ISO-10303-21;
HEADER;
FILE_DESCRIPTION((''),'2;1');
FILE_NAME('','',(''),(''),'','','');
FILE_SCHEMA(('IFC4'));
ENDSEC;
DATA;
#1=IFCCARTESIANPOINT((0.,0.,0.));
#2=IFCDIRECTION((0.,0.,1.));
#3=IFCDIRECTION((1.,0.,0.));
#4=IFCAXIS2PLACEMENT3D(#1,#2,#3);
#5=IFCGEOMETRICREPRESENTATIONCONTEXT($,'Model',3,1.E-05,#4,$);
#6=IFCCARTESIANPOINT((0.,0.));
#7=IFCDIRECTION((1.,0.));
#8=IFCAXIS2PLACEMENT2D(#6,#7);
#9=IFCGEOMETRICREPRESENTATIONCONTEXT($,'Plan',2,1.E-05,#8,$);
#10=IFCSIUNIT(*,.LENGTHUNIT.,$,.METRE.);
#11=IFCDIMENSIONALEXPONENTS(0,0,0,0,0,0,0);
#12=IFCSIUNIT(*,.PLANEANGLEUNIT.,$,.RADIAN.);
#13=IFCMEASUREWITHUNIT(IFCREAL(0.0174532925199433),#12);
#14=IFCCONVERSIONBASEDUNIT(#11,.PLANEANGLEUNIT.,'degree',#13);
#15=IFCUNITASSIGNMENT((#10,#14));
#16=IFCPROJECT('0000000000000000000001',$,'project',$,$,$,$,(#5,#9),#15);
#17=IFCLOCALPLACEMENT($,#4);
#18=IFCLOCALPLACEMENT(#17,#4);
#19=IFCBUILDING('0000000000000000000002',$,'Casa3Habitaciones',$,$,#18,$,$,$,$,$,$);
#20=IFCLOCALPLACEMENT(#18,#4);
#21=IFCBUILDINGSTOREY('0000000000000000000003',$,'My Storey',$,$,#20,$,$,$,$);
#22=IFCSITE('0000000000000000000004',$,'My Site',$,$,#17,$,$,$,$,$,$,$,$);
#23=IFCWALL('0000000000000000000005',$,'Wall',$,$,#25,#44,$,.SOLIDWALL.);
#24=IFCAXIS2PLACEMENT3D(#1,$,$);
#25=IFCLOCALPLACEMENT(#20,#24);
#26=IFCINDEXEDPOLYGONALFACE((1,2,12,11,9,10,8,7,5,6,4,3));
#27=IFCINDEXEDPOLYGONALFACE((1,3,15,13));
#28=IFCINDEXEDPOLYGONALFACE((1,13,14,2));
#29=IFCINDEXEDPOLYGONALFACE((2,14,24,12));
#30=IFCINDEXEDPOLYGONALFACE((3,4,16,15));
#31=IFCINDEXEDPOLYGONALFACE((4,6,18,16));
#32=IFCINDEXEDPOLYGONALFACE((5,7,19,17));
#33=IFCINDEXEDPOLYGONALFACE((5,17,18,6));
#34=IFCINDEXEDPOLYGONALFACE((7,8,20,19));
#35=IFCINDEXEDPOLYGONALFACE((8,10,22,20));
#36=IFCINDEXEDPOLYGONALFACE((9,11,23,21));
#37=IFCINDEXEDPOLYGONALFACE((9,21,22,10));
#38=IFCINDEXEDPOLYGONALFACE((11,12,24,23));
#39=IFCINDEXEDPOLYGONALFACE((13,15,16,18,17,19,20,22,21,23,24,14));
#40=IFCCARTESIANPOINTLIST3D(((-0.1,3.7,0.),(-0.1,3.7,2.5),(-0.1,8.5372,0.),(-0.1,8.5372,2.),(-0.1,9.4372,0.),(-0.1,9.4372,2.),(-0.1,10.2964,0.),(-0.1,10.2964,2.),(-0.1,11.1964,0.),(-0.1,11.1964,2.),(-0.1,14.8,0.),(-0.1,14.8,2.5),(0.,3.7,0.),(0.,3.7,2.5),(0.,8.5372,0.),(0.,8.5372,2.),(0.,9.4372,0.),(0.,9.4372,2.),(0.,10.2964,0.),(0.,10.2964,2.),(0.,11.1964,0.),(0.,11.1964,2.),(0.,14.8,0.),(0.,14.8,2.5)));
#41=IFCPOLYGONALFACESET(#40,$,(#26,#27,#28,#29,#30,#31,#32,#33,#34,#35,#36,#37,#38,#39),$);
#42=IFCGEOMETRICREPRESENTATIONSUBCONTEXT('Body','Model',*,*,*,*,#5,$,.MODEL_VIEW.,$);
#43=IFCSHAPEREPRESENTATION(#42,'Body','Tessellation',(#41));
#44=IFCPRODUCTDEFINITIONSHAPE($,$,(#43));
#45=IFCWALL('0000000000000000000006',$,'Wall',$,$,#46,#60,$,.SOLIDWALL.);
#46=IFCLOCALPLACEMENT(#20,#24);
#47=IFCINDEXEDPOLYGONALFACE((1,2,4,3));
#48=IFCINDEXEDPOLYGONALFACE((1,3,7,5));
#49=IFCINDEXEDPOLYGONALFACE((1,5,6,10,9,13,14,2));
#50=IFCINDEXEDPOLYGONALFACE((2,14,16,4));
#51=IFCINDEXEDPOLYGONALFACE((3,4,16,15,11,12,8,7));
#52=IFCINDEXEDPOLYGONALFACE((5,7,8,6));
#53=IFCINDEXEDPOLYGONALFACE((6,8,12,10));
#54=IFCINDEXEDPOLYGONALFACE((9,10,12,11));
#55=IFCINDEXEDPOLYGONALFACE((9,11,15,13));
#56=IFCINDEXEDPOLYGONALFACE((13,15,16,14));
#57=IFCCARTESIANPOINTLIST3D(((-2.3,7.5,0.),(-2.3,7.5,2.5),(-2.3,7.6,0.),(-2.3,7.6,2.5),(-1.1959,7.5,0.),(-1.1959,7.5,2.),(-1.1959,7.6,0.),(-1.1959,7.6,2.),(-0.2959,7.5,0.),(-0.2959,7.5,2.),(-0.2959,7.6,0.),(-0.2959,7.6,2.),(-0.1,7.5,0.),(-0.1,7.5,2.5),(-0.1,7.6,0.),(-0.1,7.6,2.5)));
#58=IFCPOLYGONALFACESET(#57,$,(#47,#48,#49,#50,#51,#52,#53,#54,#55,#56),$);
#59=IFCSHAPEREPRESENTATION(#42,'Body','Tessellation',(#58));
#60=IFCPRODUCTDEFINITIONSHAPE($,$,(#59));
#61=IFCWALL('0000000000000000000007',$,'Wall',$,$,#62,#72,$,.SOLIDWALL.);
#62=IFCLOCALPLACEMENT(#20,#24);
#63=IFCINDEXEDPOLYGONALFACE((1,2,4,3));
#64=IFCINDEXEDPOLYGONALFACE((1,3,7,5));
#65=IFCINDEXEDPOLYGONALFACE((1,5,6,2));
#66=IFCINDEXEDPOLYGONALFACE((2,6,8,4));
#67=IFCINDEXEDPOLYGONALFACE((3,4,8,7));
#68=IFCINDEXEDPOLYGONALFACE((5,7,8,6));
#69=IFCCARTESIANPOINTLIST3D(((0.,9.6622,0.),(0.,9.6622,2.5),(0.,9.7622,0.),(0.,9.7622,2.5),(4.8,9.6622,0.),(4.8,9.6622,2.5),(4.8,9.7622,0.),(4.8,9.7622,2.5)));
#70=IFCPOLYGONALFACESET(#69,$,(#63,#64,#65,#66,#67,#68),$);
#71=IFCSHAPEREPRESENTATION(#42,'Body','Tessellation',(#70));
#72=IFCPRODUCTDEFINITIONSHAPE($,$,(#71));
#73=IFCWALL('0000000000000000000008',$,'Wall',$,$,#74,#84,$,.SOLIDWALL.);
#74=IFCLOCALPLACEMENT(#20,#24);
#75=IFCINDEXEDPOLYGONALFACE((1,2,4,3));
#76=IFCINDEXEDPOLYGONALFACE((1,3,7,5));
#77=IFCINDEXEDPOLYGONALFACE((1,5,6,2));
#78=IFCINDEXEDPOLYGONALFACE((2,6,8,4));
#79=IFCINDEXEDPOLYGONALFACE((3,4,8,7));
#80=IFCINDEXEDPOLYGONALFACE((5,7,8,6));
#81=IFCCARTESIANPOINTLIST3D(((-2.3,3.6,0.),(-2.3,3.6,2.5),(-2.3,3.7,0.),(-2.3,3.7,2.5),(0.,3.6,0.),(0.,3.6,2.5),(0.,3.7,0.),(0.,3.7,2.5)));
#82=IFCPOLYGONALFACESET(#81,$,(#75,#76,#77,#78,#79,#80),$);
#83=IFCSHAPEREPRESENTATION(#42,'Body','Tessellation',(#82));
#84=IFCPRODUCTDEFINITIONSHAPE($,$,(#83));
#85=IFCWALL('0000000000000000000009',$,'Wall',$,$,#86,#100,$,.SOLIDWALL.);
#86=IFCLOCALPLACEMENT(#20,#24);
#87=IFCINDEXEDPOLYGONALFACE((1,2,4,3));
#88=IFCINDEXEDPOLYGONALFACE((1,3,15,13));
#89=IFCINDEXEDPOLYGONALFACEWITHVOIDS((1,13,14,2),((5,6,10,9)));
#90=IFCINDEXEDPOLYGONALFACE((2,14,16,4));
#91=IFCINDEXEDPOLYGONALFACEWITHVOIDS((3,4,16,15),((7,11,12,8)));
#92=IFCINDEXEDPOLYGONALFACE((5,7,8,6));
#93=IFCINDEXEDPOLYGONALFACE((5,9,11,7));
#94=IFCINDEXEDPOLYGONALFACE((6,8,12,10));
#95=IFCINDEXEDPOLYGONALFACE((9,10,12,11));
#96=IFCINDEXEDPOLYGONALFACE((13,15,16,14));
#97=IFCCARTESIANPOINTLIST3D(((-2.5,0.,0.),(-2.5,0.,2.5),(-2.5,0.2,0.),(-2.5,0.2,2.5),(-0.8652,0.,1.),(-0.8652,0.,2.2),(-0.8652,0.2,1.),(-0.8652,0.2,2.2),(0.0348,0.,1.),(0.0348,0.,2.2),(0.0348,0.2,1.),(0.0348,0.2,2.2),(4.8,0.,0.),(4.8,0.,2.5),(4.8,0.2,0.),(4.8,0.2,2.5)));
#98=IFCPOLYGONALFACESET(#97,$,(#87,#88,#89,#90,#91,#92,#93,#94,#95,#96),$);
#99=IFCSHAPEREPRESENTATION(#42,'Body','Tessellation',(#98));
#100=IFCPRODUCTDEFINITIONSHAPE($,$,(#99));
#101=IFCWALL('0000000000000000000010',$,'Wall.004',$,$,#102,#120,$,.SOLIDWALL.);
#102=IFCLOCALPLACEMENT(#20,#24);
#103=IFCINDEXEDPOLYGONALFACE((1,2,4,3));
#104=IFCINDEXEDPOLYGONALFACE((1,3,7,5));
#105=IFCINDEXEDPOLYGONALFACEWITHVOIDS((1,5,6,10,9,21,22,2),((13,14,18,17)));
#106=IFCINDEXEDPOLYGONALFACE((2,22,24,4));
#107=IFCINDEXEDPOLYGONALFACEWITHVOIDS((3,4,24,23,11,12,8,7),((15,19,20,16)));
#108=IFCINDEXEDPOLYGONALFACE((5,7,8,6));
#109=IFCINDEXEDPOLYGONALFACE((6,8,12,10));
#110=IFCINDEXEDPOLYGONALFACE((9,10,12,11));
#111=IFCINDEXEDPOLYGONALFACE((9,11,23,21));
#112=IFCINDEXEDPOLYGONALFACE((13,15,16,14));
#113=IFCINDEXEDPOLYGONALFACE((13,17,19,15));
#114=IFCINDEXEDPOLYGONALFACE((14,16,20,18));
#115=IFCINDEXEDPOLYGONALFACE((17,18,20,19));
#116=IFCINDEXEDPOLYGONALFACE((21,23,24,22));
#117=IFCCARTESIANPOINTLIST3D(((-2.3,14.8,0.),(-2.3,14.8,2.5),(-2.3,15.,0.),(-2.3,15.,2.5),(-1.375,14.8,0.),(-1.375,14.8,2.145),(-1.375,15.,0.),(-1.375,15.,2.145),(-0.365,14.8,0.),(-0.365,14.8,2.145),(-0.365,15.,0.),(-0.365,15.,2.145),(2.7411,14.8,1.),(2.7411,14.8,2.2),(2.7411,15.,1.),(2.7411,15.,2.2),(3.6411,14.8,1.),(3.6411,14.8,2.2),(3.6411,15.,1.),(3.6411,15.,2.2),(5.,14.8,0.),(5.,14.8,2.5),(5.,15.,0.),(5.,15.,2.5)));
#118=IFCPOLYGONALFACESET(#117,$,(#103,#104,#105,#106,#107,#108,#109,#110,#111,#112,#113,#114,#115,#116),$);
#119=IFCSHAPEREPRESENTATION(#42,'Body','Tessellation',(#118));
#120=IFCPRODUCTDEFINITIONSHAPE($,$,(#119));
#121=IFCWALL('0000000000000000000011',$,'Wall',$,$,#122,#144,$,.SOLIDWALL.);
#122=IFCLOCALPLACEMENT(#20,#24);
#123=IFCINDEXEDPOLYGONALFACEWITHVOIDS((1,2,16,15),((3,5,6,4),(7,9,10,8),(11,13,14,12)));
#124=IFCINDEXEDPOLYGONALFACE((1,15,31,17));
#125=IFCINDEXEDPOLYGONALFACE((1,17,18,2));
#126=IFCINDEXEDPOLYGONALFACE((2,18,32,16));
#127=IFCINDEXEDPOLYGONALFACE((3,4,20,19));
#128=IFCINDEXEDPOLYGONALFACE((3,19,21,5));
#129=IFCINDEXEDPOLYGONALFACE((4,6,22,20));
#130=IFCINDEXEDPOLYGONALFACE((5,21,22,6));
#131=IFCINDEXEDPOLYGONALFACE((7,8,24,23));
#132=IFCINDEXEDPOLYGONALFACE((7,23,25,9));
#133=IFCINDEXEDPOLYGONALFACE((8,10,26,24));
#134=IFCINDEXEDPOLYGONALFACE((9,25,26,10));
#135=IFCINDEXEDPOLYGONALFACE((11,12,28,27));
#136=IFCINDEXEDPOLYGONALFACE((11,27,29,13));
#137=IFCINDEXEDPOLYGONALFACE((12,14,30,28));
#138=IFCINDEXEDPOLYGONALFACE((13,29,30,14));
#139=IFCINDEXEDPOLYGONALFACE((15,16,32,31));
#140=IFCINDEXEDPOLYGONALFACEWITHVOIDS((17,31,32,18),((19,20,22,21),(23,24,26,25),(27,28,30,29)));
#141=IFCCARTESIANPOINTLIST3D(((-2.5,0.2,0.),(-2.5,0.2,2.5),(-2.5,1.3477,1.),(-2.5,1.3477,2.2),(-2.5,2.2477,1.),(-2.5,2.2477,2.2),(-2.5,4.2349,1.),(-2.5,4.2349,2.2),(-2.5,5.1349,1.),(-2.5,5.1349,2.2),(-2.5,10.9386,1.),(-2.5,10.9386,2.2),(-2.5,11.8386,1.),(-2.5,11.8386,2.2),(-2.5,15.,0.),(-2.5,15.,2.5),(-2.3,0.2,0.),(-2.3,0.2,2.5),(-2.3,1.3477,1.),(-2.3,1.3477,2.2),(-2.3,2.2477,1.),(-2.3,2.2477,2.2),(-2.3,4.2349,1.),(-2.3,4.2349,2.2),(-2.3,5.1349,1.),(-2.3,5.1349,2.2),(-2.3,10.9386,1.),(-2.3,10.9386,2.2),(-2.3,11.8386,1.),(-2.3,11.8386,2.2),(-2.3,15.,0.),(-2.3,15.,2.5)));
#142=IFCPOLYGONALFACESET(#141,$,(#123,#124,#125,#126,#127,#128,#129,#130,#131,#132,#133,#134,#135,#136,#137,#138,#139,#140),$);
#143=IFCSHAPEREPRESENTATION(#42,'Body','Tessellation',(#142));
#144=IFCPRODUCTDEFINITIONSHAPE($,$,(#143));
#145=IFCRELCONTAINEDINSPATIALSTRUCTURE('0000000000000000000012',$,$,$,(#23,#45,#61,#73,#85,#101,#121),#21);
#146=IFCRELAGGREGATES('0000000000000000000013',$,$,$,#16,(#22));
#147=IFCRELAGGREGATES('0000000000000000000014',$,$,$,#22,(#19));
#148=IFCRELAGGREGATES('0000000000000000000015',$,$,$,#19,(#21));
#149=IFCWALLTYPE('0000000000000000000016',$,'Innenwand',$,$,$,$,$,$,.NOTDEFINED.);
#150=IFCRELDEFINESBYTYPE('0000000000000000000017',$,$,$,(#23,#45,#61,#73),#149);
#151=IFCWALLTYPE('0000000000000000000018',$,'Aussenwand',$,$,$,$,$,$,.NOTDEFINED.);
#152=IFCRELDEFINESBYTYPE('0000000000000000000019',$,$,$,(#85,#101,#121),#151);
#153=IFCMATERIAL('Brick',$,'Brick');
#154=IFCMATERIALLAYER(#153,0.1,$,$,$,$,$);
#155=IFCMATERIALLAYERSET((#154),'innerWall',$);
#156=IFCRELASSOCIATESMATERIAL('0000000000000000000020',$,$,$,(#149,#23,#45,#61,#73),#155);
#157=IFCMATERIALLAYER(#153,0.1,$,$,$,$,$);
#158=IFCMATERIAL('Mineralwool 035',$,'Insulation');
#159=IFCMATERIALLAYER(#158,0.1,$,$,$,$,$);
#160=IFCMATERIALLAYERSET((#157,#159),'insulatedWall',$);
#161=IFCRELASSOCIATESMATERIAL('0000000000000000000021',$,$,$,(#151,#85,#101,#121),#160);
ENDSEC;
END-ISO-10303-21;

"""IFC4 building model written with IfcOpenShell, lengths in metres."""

from ifc_helpers import new_model, entity, si_unit, converted_unit, frame, origin_with_axes, origin_2d_with_axis, place, context, subcontext, project, spatial, line, indexed_curve, outline, extrude, source, transform, mapped, material, layer, layer_set, layer_usage, type_object, element, save


model = new_model("IFC4")

# Units and contexts
model_context = context("Model", 3, precision=1e-05, world=origin_with_axes())
plan_context = context("Plan", 2, precision=1e-05, world=origin_2d_with_axis())
body_context = subcontext(model_context, "Body", "Model", "MODEL_VIEW")
ifc_project = project(units=[si_unit("LENGTHUNIT", "METRE"), converted_unit("PLANEANGLEUNIT", "degree", entity("IfcReal", 0.0174532925199433), si_unit("PLANEANGLEUNIT", "RADIAN"), dimensions=[0, 0, 0, 0, 0, 0, 0])], contexts=[model_context, plan_context])

# Site, building, storey
site_placement = place(None, origin_with_axes())
site = spatial("IfcSite", under=ifc_project, at=site_placement, Name="My Site")
building_placement = place(site_placement, origin_with_axes())
building = spatial("IfcBuilding", under=site, at=building_placement, Name="Casa3Habitaciones")
storey_placement = place(building_placement, origin_with_axes())
storey = spatial("IfcBuildingStorey", under=building, at=storey_placement, Name="My Storey")

# Wall, openings
ifc_material_1 = material(Name="Brick", Category="Brick")
ifc_layer_1 = layer(ifc_material_1, 0.1)
ifc_layer_set_1 = layer_set([ifc_layer_1], Name="innerWall")
ifc_layer_usage_1 = layer_usage(ifc_layer_set_1, "AXIS2", "POSITIVE", 0.0)
wall_type_1 = type_object("IfcWallType", Name="Innenwand", PredefinedType="NOTDEFINED", material=ifc_layer_set_1)
wall_1_placement = place(storey_placement, frame((-0.1, 14.8, 0.0), z_axis=(0.0, 0.0, 1.0), x_axis=(0.0, -1.0, 0.0)))
wall_1 = element("IfcWall", 1, at=wall_1_placement, inside=storey, type_object=wall_type_1, material=ifc_layer_usage_1, Name="Wall", PredefinedType="SOLIDWALL", context=body_context, shape_type="SweptSolid", body=[
    extrude(outline(indexed_curve([(0.0, 0.0), (0.0, 0.1), (11.1, 0.1), (11.1, 0.0), (0.0, 0.0)], self_intersect=False)), origin_with_axes(), (0.0, 0.0, 1.0), 2.5),
])
shared_shape_1 = source(origin_with_axes(), body_context, "Body", "SweptSolid", [
    extrude(outline(indexed_curve([(0.0, 0.0), (0.9, 0.0), (0.9, 2.0), (0.0, 2.0)], segments=[line(1, 2, 3, 4, 1)])), frame((0.0, -0.6, 0.0), z_axis=(0.0, -1.0, 0.0), x_axis=(1.0, 0.0, 0.0)), (0.0, 0.0, -1.0), 1.2),
])
opening_1_placement = place(wall_1_placement, frame((5.3628, 0.115, 0.0), z_axis=(0.0, 0.0, 1.0), x_axis=(1.0, 0.0, 0.0)))
element("IfcOpeningElement", 2, at=opening_1_placement, cuts=wall_1, PredefinedType="OPENING", context=body_context, shape_type="MappedRepresentation", body=[
    mapped(shared_shape_1, transform((0.0, 0.0, 0.0), x_axis=(1.0, 0.0, 0.0), y_axis=(0.0, 1.0, 0.0), z_axis=(0.0, 0.0, 1.0), scale=1.0)),
])
opening_2_placement = place(wall_1_placement, frame((3.6036, 0.0, 0.0), z_axis=(0.0, 0.0, 1.0), x_axis=(1.0, 0.0, 0.0)))
element("IfcOpeningElement", 3, at=opening_2_placement, cuts=wall_1, PredefinedType="OPENING", context=body_context, shape_type="MappedRepresentation", body=[
    mapped(shared_shape_1, transform((0.0, 0.0, 0.0), x_axis=(1.0, 0.0, 0.0), y_axis=(0.0, 1.0, 0.0), z_axis=(0.0, 0.0, 1.0), scale=1.0)),
])

# Wall, opening
ifc_layer_usage_2 = layer_usage(ifc_layer_set_1, "AXIS2", "POSITIVE", 0.0)
wall_2_placement = place(storey_placement, frame((-2.3, 7.5, 0.0), z_axis=(0.0, 0.0, 1.0), x_axis=(1.0, 0.0, 0.0)))
wall_2 = element("IfcWall", 4, at=wall_2_placement, inside=storey, type_object=wall_type_1, material=ifc_layer_usage_2, Name="Wall", PredefinedType="SOLIDWALL", context=body_context, shape_type="SweptSolid", body=[
    extrude(outline(indexed_curve([(0.0, 0.0), (0.0, 0.1), (2.2, 0.1), (2.2, 0.0), (0.0, 0.0)], self_intersect=False)), origin_with_axes(), (0.0, 0.0, 1.0), 2.5),
])
opening_3_placement = place(wall_2_placement, frame((2.0041, 0.085, 0.0), z_axis=(0.0, 0.0, 1.0), x_axis=(-1.0, 0.0, 0.0)))
element("IfcOpeningElement", 5, at=opening_3_placement, cuts=wall_2, PredefinedType="OPENING", context=body_context, shape_type="MappedRepresentation", body=[
    mapped(shared_shape_1, transform((0.0, 0.0, 0.0), x_axis=(1.0, 0.0, 0.0), y_axis=(0.0, 1.0, 0.0), z_axis=(0.0, 0.0, 1.0), scale=1.0)),
])

# Walls
ifc_layer_usage_3 = layer_usage(ifc_layer_set_1, "AXIS2", "POSITIVE", 0.0)
wall_3_placement = place(storey_placement, frame((0.0, 9.6622, 0.0), z_axis=(0.0, 0.0, 1.0), x_axis=(1.0, 0.0, 0.0)))
element("IfcWall", 6, at=wall_3_placement, inside=storey, type_object=wall_type_1, material=ifc_layer_usage_3, Name="Wall", PredefinedType="SOLIDWALL", context=body_context, shape_type="SweptSolid", body=[
    extrude(outline(indexed_curve([(0.0, 0.0), (0.0, 0.1), (4.8, 0.1), (4.8, 0.0), (0.0, 0.0)], self_intersect=False)), origin_with_axes(), (0.0, 0.0, 1.0), 2.5),
])
ifc_layer_usage_4 = layer_usage(ifc_layer_set_1, "AXIS2", "POSITIVE", 0.0)
wall_4_placement = place(storey_placement, frame((-2.3, 3.6, 0.0), z_axis=(0.0, 0.0, 1.0), x_axis=(1.0, 0.0, 0.0)))
element("IfcWall", 7, at=wall_4_placement, inside=storey, type_object=wall_type_1, material=ifc_layer_usage_4, Name="Wall", PredefinedType="SOLIDWALL", context=body_context, shape_type="SweptSolid", body=[
    extrude(outline(indexed_curve([(0.0, 0.0), (0.0, 0.1), (2.3, 0.1), (2.3, 0.0), (0.0, 0.0)], self_intersect=False)), origin_with_axes(), (0.0, 0.0, 1.0), 2.5),
])

# Wall, opening
ifc_layer_2 = layer(ifc_material_1, 0.1)
ifc_material_2 = material(Name="Mineralwool 035", Category="Insulation")
ifc_layer_3 = layer(ifc_material_2, 0.1)
ifc_layer_set_2 = layer_set([ifc_layer_2, ifc_layer_3], Name="insulatedWall")
ifc_layer_usage_5 = layer_usage(ifc_layer_set_2, "AXIS2", "POSITIVE", 0.0)
wall_type_2 = type_object("IfcWallType", Name="Aussenwand", PredefinedType="NOTDEFINED", material=ifc_layer_set_2)
wall_5_placement = place(storey_placement, frame((-2.5, 0.0, 0.0), z_axis=(0.0, 0.0, 1.0), x_axis=(1.0, 0.0, 0.0)))
wall_5 = element("IfcWall", 8, at=wall_5_placement, inside=storey, type_object=wall_type_2, material=ifc_layer_usage_5, Name="Wall", PredefinedType="SOLIDWALL", context=body_context, shape_type="SweptSolid", body=[
    extrude(outline(indexed_curve([(0.0, 0.0), (0.0, 0.2), (7.3, 0.2), (7.3, 0.0), (0.0, 0.0)], self_intersect=False)), origin_with_axes(), (0.0, 0.0, 1.0), 2.5),
])
shared_shape_2 = source(origin_with_axes(), body_context, "Body", "SweptSolid", [
    extrude(outline(indexed_curve([(0.0, 0.0), (0.9, 0.0), (0.9, 1.2), (0.0, 1.2)], segments=[line(1, 2, 3, 4, 1)])), frame((0.0, -0.6, 0.0), z_axis=(0.0, -1.0, 0.0), x_axis=(1.0, 0.0, 0.0)), (0.0, 0.0, -1.0), 1.2),
])
opening_4_placement = place(wall_5_placement, frame((1.6348, 0.0, 1.0), z_axis=(0.0, 0.0, 1.0), x_axis=(1.0, 0.0, 0.0)))
element("IfcOpeningElement", 9, at=opening_4_placement, cuts=wall_5, PredefinedType="OPENING", context=body_context, shape_type="MappedRepresentation", body=[
    mapped(shared_shape_2, transform((0.0, 0.0, 0.0), x_axis=(1.0, 0.0, 0.0), y_axis=(0.0, 1.0, 0.0), z_axis=(0.0, 0.0, 1.0), scale=1.0)),
])

# Walls, openings
ifc_layer_usage_6 = layer_usage(ifc_layer_set_2, "AXIS2", "POSITIVE", 0.0)
wall_6_placement = place(storey_placement, frame((-2.3, 14.8, 0.0), z_axis=(0.0, 0.0, 1.0), x_axis=(1.0, 0.0, 0.0)))
wall_6 = element("IfcWall", 10, at=wall_6_placement, inside=storey, type_object=wall_type_2, material=ifc_layer_usage_6, Name="Wall.004", PredefinedType="SOLIDWALL", context=body_context, shape_type="SweptSolid", body=[
    extrude(outline(indexed_curve([(0.0, 0.0), (0.0, 0.2), (7.3, 0.2), (7.3, 0.0), (0.0, 0.0)], self_intersect=False)), origin_with_axes(), (0.0, 0.0, 1.0), 2.5),
])
shared_shape_3 = source(origin_with_axes(), body_context, "Body", "SweptSolid", [
    extrude(outline(indexed_curve([(0.0, 0.0), (1.01, 0.0), (1.01, 2.145), (0.0, 2.145)], segments=[line(1, 2, 3, 4, 1)])), frame((0.0, -0.6, 0.0), z_axis=(0.0, -1.0, 0.0), x_axis=(1.0, 0.0, 0.0)), (0.0, 0.0, -1.0), 1.2),
])
opening_5_placement = place(wall_6_placement, frame((0.925, 0.1, 0.0), z_axis=(0.0, 0.0, 1.0), x_axis=(1.0, 0.0, 0.0)))
element("IfcOpeningElement", 11, at=opening_5_placement, cuts=wall_6, PredefinedType="OPENING", context=body_context, shape_type="MappedRepresentation", body=[
    mapped(shared_shape_3, transform((0.0, 0.0, 0.0), x_axis=(1.0, 0.0, 0.0), y_axis=(0.0, 1.0, 0.0), z_axis=(0.0, 0.0, 1.0), scale=1.0)),
])
opening_6_placement = place(wall_6_placement, frame((5.9411, 0.0, 1.0), z_axis=(0.0, 0.0, 1.0), x_axis=(-1.0, 0.0, 0.0)))
element("IfcOpeningElement", 12, at=opening_6_placement, cuts=wall_6, PredefinedType="OPENING", context=body_context, shape_type="MappedRepresentation", body=[
    mapped(shared_shape_2, transform((0.0, 0.0, 0.0), x_axis=(1.0, 0.0, 0.0), y_axis=(0.0, 1.0, 0.0), z_axis=(0.0, 0.0, 1.0), scale=1.0)),
])
ifc_layer_usage_7 = layer_usage(ifc_layer_set_2, "AXIS2", "POSITIVE", 0.0)
wall_7_placement = place(storey_placement, frame((-2.3, 0.2, 0.0), z_axis=(0.0, 0.0, 1.0), x_axis=(0.000001, 1.0, 0.0)))
wall_7 = element("IfcWall", 13, at=wall_7_placement, inside=storey, type_object=wall_type_2, material=ifc_layer_usage_7, Name="Wall", PredefinedType="SOLIDWALL", context=body_context, shape_type="SweptSolid", body=[
    extrude(outline(indexed_curve([(0.0, 0.0), (0.0, 0.2), (14.8, 0.2), (14.8, 0.0), (0.0, 0.0)], self_intersect=False)), origin_with_axes(), (0.0, 0.0, 1.0), 2.5),
])
opening_7_placement = place(wall_7_placement, frame((4.0349, 0.15, 1.0), z_axis=(0.0, 0.0, 1.0), x_axis=(1.0, 0.0, 0.0)))
element("IfcOpeningElement", 14, at=opening_7_placement, cuts=wall_7, PredefinedType="OPENING", context=body_context, shape_type="MappedRepresentation", body=[
    mapped(shared_shape_2, transform((0.0, 0.0, 0.0), x_axis=(1.0, 0.0, 0.0), y_axis=(0.0, 1.0, 0.0), z_axis=(0.0, 0.0, 1.0), scale=1.0)),
])
opening_8_placement = place(wall_7_placement, frame((1.1477, 0.15, 1.0), z_axis=(0.0, 0.0, 1.0), x_axis=(1.0, 0.0, 0.0)))
element("IfcOpeningElement", 15, at=opening_8_placement, cuts=wall_7, PredefinedType="OPENING", context=body_context, shape_type="MappedRepresentation", body=[
    mapped(shared_shape_2, transform((0.0, 0.0, 0.0), x_axis=(1.0, 0.0, 0.0), y_axis=(0.0, 1.0, 0.0), z_axis=(0.0, 0.0, 1.0), scale=1.0)),
])
opening_9_placement = place(wall_7_placement, frame((10.7386, 0.0, 1.0), z_axis=(0.0, 0.0, 1.0), x_axis=(1.0, 0.0, 0.0)))
element("IfcOpeningElement", 16, at=opening_9_placement, cuts=wall_7, PredefinedType="OPENING", context=body_context, shape_type="MappedRepresentation", body=[
    mapped(shared_shape_2, transform((0.0, 0.0, 0.0), x_axis=(1.0, 0.0, 0.0), y_axis=(0.0, 1.0, 0.0), z_axis=(0.0, 0.0, 1.0), scale=1.0)),
])

save(model, "model.ifc")
